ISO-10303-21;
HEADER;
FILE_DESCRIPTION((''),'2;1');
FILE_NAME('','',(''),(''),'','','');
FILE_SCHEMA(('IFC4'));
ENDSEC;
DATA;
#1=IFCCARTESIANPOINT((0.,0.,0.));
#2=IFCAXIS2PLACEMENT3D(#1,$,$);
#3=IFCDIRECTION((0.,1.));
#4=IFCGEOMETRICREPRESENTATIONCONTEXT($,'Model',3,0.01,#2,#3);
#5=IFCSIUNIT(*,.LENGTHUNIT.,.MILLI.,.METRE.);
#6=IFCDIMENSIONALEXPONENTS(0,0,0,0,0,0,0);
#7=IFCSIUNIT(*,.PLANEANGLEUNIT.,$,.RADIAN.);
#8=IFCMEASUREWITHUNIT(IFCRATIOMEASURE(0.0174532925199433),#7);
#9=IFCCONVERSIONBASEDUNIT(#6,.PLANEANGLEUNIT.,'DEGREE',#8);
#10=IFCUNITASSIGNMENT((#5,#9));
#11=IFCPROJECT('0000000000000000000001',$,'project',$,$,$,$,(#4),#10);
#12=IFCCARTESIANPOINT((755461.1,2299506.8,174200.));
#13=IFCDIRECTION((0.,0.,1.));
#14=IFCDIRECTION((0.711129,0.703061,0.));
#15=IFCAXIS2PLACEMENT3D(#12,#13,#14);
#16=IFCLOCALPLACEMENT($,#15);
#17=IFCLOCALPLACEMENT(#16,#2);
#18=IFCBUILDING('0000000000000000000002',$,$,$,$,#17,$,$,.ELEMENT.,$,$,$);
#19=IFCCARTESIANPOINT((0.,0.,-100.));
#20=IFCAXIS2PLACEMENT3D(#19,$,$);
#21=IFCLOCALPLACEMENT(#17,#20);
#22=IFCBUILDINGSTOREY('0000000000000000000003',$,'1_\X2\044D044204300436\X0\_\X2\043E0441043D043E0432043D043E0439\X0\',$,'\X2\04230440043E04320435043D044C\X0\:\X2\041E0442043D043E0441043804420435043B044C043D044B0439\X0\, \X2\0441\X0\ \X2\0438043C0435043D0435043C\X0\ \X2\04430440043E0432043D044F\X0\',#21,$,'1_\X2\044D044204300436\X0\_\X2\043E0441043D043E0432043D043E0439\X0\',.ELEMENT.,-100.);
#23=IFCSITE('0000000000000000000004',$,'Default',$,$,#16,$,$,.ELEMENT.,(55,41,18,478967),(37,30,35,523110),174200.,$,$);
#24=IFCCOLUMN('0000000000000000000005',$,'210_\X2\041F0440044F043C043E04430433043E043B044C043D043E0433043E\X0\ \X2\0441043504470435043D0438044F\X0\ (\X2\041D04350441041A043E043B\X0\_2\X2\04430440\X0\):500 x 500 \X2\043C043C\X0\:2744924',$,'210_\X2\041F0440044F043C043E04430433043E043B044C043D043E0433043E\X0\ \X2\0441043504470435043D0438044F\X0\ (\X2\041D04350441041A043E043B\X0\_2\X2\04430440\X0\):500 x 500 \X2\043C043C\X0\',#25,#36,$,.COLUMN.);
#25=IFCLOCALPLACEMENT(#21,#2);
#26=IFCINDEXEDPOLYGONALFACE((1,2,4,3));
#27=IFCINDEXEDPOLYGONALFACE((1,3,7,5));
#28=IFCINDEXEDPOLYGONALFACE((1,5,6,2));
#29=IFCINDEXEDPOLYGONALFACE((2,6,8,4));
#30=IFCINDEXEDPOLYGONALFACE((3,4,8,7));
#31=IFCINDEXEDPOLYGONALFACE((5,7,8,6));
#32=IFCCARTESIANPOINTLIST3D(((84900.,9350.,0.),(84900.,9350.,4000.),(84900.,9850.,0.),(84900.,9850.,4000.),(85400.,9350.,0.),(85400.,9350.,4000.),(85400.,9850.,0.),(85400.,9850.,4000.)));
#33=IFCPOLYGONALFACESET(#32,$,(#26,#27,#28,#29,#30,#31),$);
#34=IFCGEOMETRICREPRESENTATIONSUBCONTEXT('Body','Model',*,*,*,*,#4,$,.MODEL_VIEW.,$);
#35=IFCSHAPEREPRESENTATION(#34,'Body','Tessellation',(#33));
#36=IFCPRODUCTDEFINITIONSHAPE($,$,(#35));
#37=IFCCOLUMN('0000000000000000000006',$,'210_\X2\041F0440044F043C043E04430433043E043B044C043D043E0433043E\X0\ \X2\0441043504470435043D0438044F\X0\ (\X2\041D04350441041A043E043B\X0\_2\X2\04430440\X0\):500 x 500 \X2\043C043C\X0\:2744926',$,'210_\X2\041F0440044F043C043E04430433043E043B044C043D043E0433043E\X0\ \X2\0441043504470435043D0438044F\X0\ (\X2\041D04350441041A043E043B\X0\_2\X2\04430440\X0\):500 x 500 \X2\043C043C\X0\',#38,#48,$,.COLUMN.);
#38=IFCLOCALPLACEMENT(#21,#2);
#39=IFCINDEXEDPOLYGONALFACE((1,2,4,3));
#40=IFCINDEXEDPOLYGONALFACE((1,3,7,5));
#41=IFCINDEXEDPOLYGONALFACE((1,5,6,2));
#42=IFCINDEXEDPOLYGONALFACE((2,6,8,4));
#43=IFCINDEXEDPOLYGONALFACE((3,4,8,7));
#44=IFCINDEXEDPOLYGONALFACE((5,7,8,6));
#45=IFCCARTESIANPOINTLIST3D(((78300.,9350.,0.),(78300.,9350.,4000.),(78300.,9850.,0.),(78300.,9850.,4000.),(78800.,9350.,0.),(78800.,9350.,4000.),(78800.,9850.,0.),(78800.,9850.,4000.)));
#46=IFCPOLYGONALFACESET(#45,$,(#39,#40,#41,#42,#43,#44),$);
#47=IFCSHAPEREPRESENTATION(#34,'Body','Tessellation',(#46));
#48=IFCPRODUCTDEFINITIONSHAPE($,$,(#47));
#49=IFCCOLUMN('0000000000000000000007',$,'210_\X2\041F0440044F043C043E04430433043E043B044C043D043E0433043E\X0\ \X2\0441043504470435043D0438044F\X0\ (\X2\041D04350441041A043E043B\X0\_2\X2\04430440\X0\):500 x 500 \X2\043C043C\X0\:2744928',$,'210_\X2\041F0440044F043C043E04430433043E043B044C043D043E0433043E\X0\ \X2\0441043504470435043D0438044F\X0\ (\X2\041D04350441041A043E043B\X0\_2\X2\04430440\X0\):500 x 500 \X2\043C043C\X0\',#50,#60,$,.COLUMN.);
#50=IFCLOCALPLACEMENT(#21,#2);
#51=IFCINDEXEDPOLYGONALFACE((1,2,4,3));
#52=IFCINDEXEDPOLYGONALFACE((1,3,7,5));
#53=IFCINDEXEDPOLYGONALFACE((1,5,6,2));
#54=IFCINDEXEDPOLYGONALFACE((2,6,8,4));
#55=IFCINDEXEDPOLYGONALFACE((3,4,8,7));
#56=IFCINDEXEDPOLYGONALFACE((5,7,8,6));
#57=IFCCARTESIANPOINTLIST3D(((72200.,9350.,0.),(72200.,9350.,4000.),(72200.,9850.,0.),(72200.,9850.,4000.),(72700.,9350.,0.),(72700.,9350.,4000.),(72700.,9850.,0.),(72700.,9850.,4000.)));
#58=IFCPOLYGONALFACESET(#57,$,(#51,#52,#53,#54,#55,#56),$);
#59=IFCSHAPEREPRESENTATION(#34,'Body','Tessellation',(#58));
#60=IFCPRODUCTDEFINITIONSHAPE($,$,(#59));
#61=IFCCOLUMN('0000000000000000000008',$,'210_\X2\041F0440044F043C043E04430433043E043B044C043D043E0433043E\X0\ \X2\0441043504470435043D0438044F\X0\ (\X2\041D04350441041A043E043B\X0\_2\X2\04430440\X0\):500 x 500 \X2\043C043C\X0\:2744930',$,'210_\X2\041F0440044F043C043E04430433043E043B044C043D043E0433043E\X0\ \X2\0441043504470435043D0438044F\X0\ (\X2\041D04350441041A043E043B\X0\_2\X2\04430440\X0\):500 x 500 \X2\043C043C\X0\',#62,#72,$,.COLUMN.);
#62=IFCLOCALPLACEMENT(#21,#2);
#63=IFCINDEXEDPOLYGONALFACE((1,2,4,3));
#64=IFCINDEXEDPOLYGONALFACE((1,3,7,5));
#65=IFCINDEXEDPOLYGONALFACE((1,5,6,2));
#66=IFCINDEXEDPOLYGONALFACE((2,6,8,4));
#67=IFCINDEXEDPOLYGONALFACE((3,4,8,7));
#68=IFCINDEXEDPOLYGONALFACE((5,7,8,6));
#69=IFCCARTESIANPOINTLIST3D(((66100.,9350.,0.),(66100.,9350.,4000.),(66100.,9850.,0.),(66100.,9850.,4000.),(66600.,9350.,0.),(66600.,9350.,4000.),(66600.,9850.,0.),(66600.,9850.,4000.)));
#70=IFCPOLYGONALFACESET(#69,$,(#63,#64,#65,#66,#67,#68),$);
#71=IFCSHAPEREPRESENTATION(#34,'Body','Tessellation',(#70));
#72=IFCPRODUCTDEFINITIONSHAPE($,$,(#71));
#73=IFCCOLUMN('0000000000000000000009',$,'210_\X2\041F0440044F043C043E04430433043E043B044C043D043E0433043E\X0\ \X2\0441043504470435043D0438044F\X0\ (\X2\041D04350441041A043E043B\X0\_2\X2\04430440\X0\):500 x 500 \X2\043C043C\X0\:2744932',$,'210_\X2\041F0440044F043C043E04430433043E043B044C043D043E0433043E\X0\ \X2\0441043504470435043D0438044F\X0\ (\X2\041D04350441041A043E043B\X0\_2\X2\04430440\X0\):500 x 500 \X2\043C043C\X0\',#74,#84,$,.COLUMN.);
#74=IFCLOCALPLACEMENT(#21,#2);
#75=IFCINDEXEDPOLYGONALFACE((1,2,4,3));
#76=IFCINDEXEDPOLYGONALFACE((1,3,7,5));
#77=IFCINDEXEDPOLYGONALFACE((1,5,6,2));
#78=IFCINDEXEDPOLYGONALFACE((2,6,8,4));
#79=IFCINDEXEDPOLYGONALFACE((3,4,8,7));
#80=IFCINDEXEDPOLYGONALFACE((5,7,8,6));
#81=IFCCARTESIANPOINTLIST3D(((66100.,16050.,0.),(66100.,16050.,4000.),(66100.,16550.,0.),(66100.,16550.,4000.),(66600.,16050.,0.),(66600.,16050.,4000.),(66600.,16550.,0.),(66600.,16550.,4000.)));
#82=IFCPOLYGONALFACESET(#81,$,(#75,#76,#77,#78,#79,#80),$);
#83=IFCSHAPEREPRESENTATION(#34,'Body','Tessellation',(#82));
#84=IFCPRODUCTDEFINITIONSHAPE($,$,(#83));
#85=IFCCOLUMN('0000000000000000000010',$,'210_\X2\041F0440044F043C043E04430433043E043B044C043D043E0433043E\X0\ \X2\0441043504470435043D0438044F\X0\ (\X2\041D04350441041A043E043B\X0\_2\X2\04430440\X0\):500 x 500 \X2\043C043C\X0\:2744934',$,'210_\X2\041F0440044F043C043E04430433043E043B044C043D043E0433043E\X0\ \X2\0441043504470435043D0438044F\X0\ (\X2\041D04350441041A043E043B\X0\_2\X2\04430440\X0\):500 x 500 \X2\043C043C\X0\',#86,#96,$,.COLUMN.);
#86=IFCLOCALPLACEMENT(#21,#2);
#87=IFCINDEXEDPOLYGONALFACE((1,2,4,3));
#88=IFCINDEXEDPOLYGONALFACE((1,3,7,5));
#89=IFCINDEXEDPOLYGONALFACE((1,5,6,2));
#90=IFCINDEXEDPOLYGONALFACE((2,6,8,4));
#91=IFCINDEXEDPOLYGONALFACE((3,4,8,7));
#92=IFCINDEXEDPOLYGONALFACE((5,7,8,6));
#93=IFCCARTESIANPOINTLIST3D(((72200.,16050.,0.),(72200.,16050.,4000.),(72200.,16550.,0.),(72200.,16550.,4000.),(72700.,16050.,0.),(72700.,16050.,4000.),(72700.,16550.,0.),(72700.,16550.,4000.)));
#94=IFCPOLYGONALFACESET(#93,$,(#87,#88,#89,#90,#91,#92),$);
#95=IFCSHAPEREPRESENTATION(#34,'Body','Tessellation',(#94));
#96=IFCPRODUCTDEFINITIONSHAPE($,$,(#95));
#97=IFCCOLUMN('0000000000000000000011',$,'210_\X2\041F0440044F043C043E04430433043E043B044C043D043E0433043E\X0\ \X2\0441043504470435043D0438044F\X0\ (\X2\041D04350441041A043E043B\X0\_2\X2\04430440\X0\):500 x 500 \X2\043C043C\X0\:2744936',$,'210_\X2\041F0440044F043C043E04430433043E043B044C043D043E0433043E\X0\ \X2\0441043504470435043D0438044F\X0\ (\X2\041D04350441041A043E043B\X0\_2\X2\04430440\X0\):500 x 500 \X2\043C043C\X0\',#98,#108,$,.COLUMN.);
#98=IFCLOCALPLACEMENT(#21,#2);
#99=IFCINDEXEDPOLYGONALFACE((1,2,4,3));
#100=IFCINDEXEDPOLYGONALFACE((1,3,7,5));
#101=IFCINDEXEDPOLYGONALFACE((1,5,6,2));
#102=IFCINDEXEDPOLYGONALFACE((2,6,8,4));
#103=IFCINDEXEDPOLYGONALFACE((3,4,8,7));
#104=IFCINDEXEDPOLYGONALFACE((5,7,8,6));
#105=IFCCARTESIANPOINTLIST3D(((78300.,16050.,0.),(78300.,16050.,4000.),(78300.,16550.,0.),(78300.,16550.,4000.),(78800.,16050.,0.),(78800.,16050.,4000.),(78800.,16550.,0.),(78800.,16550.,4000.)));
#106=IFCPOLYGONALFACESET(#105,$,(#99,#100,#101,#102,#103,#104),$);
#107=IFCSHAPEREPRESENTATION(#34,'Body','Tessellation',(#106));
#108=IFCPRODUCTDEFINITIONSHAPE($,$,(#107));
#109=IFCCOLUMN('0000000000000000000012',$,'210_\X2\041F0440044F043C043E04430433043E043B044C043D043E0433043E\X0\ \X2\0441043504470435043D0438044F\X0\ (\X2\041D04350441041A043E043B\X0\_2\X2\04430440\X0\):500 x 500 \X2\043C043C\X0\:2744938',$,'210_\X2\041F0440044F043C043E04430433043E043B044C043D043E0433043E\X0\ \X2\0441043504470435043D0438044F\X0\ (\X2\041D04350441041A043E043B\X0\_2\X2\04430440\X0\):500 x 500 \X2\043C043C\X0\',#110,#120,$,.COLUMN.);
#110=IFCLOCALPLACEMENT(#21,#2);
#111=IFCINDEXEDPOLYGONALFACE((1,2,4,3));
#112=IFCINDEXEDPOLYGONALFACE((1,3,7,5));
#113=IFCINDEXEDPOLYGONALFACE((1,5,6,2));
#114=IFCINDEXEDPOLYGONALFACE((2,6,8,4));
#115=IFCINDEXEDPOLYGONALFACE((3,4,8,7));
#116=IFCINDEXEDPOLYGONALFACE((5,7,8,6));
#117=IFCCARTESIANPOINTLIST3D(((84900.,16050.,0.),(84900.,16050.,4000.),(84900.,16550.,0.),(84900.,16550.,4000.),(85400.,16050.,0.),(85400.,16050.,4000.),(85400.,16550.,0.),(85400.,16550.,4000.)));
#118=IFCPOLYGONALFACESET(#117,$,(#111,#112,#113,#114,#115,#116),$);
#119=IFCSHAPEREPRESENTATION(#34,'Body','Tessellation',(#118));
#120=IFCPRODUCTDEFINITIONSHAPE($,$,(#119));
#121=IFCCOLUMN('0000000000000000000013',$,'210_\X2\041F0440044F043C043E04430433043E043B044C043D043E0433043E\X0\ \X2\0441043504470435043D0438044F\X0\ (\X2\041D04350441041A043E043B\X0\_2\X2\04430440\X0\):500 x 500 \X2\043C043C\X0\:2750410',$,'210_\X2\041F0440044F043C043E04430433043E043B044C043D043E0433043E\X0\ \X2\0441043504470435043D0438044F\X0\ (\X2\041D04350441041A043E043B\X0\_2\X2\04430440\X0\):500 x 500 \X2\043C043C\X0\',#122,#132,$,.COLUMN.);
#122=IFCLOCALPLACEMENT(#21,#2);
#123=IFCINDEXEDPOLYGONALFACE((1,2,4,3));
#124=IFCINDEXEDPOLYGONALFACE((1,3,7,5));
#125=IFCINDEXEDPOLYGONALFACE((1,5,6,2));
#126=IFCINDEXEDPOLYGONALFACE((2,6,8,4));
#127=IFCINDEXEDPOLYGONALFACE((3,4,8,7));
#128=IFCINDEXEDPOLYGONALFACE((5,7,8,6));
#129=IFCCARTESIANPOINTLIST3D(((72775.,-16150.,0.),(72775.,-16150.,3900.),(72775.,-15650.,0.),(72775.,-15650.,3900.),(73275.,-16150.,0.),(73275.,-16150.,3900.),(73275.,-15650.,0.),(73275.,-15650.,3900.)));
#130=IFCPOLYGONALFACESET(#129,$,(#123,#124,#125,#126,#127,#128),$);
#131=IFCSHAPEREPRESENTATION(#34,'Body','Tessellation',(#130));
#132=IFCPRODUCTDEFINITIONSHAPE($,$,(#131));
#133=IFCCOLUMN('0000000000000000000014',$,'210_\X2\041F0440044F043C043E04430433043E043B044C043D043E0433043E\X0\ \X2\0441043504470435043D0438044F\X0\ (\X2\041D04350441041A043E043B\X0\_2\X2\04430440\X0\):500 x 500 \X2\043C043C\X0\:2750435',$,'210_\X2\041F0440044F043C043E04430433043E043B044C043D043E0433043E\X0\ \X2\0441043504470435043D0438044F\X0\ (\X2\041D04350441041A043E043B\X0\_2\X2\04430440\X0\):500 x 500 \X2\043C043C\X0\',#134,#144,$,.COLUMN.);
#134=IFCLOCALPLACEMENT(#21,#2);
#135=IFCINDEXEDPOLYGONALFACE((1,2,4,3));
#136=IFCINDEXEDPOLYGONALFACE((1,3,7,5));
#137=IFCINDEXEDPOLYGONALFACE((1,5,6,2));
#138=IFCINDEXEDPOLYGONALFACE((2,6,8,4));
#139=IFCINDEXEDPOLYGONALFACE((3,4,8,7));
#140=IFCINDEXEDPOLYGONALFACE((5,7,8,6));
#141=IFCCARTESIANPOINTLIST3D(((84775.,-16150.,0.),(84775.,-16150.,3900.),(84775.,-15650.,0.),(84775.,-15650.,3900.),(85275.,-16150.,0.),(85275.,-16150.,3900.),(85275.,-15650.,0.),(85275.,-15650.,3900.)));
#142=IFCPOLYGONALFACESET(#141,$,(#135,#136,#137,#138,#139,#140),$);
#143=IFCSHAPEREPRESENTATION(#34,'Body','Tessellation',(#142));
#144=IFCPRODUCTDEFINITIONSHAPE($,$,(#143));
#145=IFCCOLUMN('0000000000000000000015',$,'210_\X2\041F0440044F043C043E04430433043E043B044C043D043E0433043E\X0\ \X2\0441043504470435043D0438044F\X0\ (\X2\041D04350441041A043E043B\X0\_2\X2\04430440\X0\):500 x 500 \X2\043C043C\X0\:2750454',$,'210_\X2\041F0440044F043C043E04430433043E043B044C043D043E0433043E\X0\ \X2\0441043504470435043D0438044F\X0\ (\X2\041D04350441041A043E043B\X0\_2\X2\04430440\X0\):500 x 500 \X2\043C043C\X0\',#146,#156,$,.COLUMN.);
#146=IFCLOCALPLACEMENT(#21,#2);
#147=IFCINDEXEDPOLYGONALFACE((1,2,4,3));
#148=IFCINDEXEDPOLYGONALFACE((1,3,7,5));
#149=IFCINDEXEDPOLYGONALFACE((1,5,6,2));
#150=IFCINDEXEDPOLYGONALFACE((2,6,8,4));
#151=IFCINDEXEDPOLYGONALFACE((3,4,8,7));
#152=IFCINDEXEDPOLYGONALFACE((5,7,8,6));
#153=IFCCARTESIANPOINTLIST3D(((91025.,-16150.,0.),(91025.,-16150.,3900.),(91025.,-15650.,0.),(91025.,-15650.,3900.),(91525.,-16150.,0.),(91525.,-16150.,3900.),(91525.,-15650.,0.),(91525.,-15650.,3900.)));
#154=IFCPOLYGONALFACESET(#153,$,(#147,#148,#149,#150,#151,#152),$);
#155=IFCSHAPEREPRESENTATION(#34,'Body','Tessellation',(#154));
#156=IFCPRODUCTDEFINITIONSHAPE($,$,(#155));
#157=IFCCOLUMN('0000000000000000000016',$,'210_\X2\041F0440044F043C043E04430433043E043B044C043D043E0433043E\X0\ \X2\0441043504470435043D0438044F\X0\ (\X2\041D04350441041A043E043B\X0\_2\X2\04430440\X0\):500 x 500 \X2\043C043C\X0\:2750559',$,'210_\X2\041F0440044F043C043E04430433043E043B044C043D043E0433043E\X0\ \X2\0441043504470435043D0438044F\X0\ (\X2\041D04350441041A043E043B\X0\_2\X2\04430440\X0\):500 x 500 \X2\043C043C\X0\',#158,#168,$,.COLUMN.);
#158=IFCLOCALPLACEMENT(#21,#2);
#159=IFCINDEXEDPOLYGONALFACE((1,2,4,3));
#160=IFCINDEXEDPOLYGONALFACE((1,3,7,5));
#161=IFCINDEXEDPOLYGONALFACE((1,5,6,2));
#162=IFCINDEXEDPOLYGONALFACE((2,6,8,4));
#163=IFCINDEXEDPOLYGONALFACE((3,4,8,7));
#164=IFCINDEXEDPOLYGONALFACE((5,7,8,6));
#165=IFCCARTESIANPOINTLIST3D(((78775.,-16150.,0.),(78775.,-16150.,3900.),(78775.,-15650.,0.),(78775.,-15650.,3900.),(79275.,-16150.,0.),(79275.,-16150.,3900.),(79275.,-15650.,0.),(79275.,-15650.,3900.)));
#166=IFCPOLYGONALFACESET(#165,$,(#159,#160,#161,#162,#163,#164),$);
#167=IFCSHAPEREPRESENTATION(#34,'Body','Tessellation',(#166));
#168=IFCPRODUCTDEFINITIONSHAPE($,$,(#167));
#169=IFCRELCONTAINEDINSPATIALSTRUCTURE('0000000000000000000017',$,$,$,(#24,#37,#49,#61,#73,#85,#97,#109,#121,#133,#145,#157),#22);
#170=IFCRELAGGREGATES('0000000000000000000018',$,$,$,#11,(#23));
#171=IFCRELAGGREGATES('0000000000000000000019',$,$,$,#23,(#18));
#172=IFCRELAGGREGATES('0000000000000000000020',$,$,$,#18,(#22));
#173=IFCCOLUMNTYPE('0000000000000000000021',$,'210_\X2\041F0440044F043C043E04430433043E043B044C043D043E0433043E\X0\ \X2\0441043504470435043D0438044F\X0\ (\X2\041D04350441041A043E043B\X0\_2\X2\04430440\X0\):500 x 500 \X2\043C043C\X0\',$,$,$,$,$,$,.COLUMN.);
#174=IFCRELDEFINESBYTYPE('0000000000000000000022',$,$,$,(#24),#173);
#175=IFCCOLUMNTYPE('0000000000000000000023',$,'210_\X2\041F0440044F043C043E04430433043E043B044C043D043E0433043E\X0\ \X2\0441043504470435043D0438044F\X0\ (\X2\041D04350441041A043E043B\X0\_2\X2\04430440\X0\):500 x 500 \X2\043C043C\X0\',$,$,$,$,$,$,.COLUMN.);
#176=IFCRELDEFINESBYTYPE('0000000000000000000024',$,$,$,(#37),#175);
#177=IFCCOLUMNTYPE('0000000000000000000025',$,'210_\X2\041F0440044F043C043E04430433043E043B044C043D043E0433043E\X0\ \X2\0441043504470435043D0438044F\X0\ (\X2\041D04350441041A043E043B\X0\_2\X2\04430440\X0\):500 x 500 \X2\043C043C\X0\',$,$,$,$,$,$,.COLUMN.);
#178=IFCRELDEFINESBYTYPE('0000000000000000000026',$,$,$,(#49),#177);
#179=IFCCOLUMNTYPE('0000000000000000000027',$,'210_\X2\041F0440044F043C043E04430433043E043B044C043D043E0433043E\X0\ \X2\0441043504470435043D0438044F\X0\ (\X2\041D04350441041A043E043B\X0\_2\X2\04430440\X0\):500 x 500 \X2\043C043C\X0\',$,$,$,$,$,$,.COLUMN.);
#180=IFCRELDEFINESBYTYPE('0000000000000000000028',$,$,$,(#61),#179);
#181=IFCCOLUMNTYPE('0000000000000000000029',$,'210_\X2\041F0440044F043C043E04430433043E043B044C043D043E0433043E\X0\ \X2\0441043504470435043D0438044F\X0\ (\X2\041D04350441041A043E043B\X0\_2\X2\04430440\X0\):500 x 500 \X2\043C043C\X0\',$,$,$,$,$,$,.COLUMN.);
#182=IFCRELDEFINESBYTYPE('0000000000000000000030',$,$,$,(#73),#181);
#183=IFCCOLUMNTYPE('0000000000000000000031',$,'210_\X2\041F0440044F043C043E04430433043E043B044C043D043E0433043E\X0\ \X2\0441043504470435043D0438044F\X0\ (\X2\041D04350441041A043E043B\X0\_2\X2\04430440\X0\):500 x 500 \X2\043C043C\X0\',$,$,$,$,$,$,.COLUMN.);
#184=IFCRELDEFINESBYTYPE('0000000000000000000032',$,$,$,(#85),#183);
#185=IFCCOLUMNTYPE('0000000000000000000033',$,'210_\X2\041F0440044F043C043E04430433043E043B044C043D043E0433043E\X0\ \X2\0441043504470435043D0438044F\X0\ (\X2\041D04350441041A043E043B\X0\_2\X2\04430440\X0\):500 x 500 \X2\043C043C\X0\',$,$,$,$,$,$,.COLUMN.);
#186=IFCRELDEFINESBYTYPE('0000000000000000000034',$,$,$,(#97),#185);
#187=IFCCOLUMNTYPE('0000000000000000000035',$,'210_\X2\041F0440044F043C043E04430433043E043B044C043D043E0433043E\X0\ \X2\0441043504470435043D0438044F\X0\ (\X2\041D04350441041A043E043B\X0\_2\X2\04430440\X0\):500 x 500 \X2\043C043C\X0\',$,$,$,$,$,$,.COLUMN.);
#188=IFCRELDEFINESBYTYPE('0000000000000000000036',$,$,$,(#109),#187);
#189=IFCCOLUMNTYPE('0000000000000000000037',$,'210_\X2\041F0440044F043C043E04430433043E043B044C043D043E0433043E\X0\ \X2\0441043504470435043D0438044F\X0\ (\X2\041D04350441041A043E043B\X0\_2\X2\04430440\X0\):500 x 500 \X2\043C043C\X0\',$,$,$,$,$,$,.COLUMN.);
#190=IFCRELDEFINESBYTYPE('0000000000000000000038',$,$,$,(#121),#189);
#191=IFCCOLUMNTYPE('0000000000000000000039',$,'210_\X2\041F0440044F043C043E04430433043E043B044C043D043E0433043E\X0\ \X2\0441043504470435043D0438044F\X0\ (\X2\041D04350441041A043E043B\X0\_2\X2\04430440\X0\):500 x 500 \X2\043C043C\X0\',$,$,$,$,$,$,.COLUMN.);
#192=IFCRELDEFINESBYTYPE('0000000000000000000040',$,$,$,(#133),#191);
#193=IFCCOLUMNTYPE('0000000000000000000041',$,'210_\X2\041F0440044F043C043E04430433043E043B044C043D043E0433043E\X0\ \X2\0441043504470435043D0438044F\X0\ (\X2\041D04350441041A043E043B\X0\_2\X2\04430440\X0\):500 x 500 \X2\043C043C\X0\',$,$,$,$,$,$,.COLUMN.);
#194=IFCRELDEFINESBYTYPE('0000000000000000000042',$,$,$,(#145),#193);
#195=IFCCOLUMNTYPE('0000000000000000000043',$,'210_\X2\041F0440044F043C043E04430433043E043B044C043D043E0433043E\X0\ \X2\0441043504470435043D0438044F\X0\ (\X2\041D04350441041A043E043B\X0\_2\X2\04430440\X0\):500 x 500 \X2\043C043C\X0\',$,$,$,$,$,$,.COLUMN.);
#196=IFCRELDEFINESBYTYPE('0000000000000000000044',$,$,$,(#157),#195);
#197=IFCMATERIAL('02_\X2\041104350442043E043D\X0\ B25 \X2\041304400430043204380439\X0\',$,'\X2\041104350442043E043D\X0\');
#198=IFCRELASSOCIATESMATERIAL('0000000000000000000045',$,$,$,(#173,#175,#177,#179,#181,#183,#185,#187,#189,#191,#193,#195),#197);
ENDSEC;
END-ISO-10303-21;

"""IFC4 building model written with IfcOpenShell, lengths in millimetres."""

from ifc_helpers import new_model, entity, si_unit, converted_unit, direction, frame, origin, place, context, subcontext, project, spatial, indexed_curve, outline, extrude, source, transform, mapped, material, type_object, type_shapes, element, save


model = new_model("IFC4")

# Units and contexts
model_context = context("Model", 3, precision=0.01, world=origin(), true_north=direction((0.0, 1.0)))
body_context = subcontext(model_context, "Body", "Model", "MODEL_VIEW")
ifc_project = project(units=[si_unit("LENGTHUNIT", "METRE", prefix="MILLI"), converted_unit("PLANEANGLEUNIT", "DEGREE", entity("IfcRatioMeasure", 0.0174532925199433), si_unit("PLANEANGLEUNIT", "RADIAN"), dimensions=[0, 0, 0, 0, 0, 0, 0])], contexts=[model_context])

# Site, building, storey
site_placement = place(None, frame((755461.1, 2299506.8, 174200.0), z_axis=(0.0, 0.0, 1.0), x_axis=(0.711129, 0.703061, 0.0)))
site = spatial("IfcSite", under=ifc_project, at=site_placement, Name="Default", CompositionType="ELEMENT", RefLatitude=(55, 41, 18, 478967), RefLongitude=(37, 30, 35, 523110), RefElevation=174200.0)
building_placement = place(site_placement, origin())
building = spatial("IfcBuilding", under=site, at=building_placement, CompositionType="ELEMENT")
storey_placement = place(building_placement, frame((0.0, 0.0, -100.0)))
storey = spatial("IfcBuildingStorey", under=building, at=storey_placement, Name="1_этаж_основной", ObjectType="Уровень:Относительный, с именем уровня", LongName="1_этаж_основной", CompositionType="ELEMENT", Elevation=-100.0)

# Columns
ifc_material_1 = material(Name="02_Бетон B25 Гравий", Category="Бетон")
column_type_1 = type_object("IfcColumnType", Name="210_Прямоугольного сечения (НесКол_2ур):500 x 500 мм", PredefinedType="COLUMN", material=ifc_material_1)
shared_shape_1 = source(origin(), body_context, "Body", "SweptSolid", [
    extrude(outline(indexed_curve([(-250.0, -250.0), (250.0, -250.0), (250.0, 250.0), (-250.0, 250.0), (-250.0, -250.0)], self_intersect=False)), frame((85150.0, 9600.0, -100.0), z_axis=(0.0, 0.0, 1.0), x_axis=(0.0, -1.0, 0.0)), (0.0, 0.0, 1.0), 4000.0),
])
type_shapes(column_type_1, [shared_shape_1])
column_1_placement = place(storey_placement, frame((0.0, 0.0, 100.0)))
element("IfcColumn", 1, at=column_1_placement, inside=storey, type_object=column_type_1, Name="210_Прямоугольного сечения (НесКол_2ур):500 x 500 мм:2744924", ObjectType="210_Прямоугольного сечения (НесКол_2ур):500 x 500 мм", PredefinedType="COLUMN", context=body_context, shape_type="MappedRepresentation", body=[
    mapped(shared_shape_1, transform((0.0, 0.0, 0.0), scale=1.0)),
])
column_type_2 = type_object("IfcColumnType", Name="210_Прямоугольного сечения (НесКол_2ур):500 x 500 мм", PredefinedType="COLUMN", material=ifc_material_1)
shared_shape_2 = source(origin(), body_context, "Body", "SweptSolid", [
    extrude(outline(indexed_curve([(-250.0, -250.0), (250.0, -250.0), (250.0, 250.0), (-250.0, 250.0), (-250.0, -250.0)], self_intersect=False)), frame((78550.0, 9600.0, -100.0), z_axis=(0.0, 0.0, 1.0), x_axis=(0.0, -1.0, 0.0)), (0.0, 0.0, 1.0), 4000.0),
])
type_shapes(column_type_2, [shared_shape_2])
column_2_placement = place(storey_placement, frame((0.0, 0.0, 100.0)))
element("IfcColumn", 2, at=column_2_placement, inside=storey, type_object=column_type_2, Name="210_Прямоугольного сечения (НесКол_2ур):500 x 500 мм:2744926", ObjectType="210_Прямоугольного сечения (НесКол_2ур):500 x 500 мм", PredefinedType="COLUMN", context=body_context, shape_type="MappedRepresentation", body=[
    mapped(shared_shape_2, transform((0.0, 0.0, 0.0), scale=1.0)),
])
column_type_3 = type_object("IfcColumnType", Name="210_Прямоугольного сечения (НесКол_2ур):500 x 500 мм", PredefinedType="COLUMN", material=ifc_material_1)
shared_shape_3 = source(origin(), body_context, "Body", "SweptSolid", [
    extrude(outline(indexed_curve([(-250.0, -250.0), (250.0, -250.0), (250.0, 250.0), (-250.0, 250.0), (-250.0, -250.0)], self_intersect=False)), frame((72450.0, 9600.0, -100.0), z_axis=(0.0, 0.0, 1.0), x_axis=(0.0, -1.0, 0.0)), (0.0, 0.0, 1.0), 4000.0),
])
type_shapes(column_type_3, [shared_shape_3])
column_3_placement = place(storey_placement, frame((0.0, 0.0, 100.0)))
element("IfcColumn", 3, at=column_3_placement, inside=storey, type_object=column_type_3, Name="210_Прямоугольного сечения (НесКол_2ур):500 x 500 мм:2744928", ObjectType="210_Прямоугольного сечения (НесКол_2ур):500 x 500 мм", PredefinedType="COLUMN", context=body_context, shape_type="MappedRepresentation", body=[
    mapped(shared_shape_3, transform((0.0, 0.0, 0.0), scale=1.0)),
])
column_type_4 = type_object("IfcColumnType", Name="210_Прямоугольного сечения (НесКол_2ур):500 x 500 мм", PredefinedType="COLUMN", material=ifc_material_1)
shared_shape_4 = source(origin(), body_context, "Body", "SweptSolid", [
    extrude(outline(indexed_curve([(-250.0, -250.0), (250.0, -250.0), (250.0, 250.0), (-250.0, 250.0), (-250.0, -250.0)], self_intersect=False)), frame((66350.0, 9600.0, -100.0), z_axis=(0.0, 0.0, 1.0), x_axis=(0.0, -1.0, 0.0)), (0.0, 0.0, 1.0), 4000.0),
])
type_shapes(column_type_4, [shared_shape_4])
column_4_placement = place(storey_placement, frame((0.0, 0.0, 100.0)))
element("IfcColumn", 4, at=column_4_placement, inside=storey, type_object=column_type_4, Name="210_Прямоугольного сечения (НесКол_2ур):500 x 500 мм:2744930", ObjectType="210_Прямоугольного сечения (НесКол_2ур):500 x 500 мм", PredefinedType="COLUMN", context=body_context, shape_type="MappedRepresentation", body=[
    mapped(shared_shape_4, transform((0.0, 0.0, 0.0), scale=1.0)),
])
column_type_5 = type_object("IfcColumnType", Name="210_Прямоугольного сечения (НесКол_2ур):500 x 500 мм", PredefinedType="COLUMN", material=ifc_material_1)
shared_shape_5 = source(origin(), body_context, "Body", "SweptSolid", [
    extrude(outline(indexed_curve([(-250.0, -250.0), (250.0, -250.0), (250.0, 250.0), (-250.0, 250.0), (-250.0, -250.0)], self_intersect=False)), frame((66350.0, 16300.0, -100.0), z_axis=(0.0, 0.0, 1.0), x_axis=(0.0, -1.0, 0.0)), (0.0, 0.0, 1.0), 4000.0),
])
type_shapes(column_type_5, [shared_shape_5])
column_5_placement = place(storey_placement, frame((0.0, 0.0, 100.0)))
element("IfcColumn", 5, at=column_5_placement, inside=storey, type_object=column_type_5, Name="210_Прямоугольного сечения (НесКол_2ур):500 x 500 мм:2744932", ObjectType="210_Прямоугольного сечения (НесКол_2ур):500 x 500 мм", PredefinedType="COLUMN", context=body_context, shape_type="MappedRepresentation", body=[
    mapped(shared_shape_5, transform((0.0, 0.0, 0.0), scale=1.0)),
])
column_type_6 = type_object("IfcColumnType", Name="210_Прямоугольного сечения (НесКол_2ур):500 x 500 мм", PredefinedType="COLUMN", material=ifc_material_1)
shared_shape_6 = source(origin(), body_context, "Body", "SweptSolid", [
    extrude(outline(indexed_curve([(-250.0, -250.0), (250.0, -250.0), (250.0, 250.0), (-250.0, 250.0), (-250.0, -250.0)], self_intersect=False)), frame((72450.0, 16300.0, -100.0), z_axis=(0.0, 0.0, 1.0), x_axis=(0.0, -1.0, 0.0)), (0.0, 0.0, 1.0), 4000.0),
])
type_shapes(column_type_6, [shared_shape_6])
column_6_placement = place(storey_placement, frame((0.0, 0.0, 100.0)))
element("IfcColumn", 6, at=column_6_placement, inside=storey, type_object=column_type_6, Name="210_Прямоугольного сечения (НесКол_2ур):500 x 500 мм:2744934", ObjectType="210_Прямоугольного сечения (НесКол_2ур):500 x 500 мм", PredefinedType="COLUMN", context=body_context, shape_type="MappedRepresentation", body=[
    mapped(shared_shape_6, transform((0.0, 0.0, 0.0), scale=1.0)),
])
column_type_7 = type_object("IfcColumnType", Name="210_Прямоугольного сечения (НесКол_2ур):500 x 500 мм", PredefinedType="COLUMN", material=ifc_material_1)
shared_shape_7 = source(origin(), body_context, "Body", "SweptSolid", [
    extrude(outline(indexed_curve([(-250.0, -250.0), (250.0, -250.0), (250.0, 250.0), (-250.0, 250.0), (-250.0, -250.0)], self_intersect=False)), frame((78550.0, 16300.0, -100.0), z_axis=(0.0, 0.0, 1.0), x_axis=(0.0, -1.0, 0.0)), (0.0, 0.0, 1.0), 4000.0),
])
type_shapes(column_type_7, [shared_shape_7])
column_7_placement = place(storey_placement, frame((0.0, 0.0, 100.0)))
element("IfcColumn", 7, at=column_7_placement, inside=storey, type_object=column_type_7, Name="210_Прямоугольного сечения (НесКол_2ур):500 x 500 мм:2744936", ObjectType="210_Прямоугольного сечения (НесКол_2ур):500 x 500 мм", PredefinedType="COLUMN", context=body_context, shape_type="MappedRepresentation", body=[
    mapped(shared_shape_7, transform((0.0, 0.0, 0.0), scale=1.0)),
])
column_type_8 = type_object("IfcColumnType", Name="210_Прямоугольного сечения (НесКол_2ур):500 x 500 мм", PredefinedType="COLUMN", material=ifc_material_1)
shared_shape_8 = source(origin(), body_context, "Body", "SweptSolid", [
    extrude(outline(indexed_curve([(-250.0, -250.0), (250.0, -250.0), (250.0, 250.0), (-250.0, 250.0), (-250.0, -250.0)], self_intersect=False)), frame((85150.0, 16300.0, -100.0), z_axis=(0.0, 0.0, 1.0), x_axis=(0.0, -1.0, 0.0)), (0.0, 0.0, 1.0), 4000.0),
])
type_shapes(column_type_8, [shared_shape_8])
column_8_placement = place(storey_placement, frame((0.0, 0.0, 100.0)))
element("IfcColumn", 8, at=column_8_placement, inside=storey, type_object=column_type_8, Name="210_Прямоугольного сечения (НесКол_2ур):500 x 500 мм:2744938", ObjectType="210_Прямоугольного сечения (НесКол_2ур):500 x 500 мм", PredefinedType="COLUMN", context=body_context, shape_type="MappedRepresentation", body=[
    mapped(shared_shape_8, transform((0.0, 0.0, 0.0), scale=1.0)),
])
column_type_9 = type_object("IfcColumnType", Name="210_Прямоугольного сечения (НесКол_2ур):500 x 500 мм", PredefinedType="COLUMN", material=ifc_material_1)
shared_shape_9 = source(origin(), body_context, "Body", "SweptSolid", [
    extrude(outline(indexed_curve([(-250.0, -250.0), (250.0, -250.0), (250.0, 250.0), (-250.0, 250.0), (-250.0, -250.0)], self_intersect=False)), frame((73025.0, -15900.0, -100.0), z_axis=(0.0, 0.0, 1.0), x_axis=(0.0, -1.0, 0.0)), (0.0, 0.0, 1.0), 3900.0),
])
type_shapes(column_type_9, [shared_shape_9])
column_9_placement = place(storey_placement, frame((0.0, 0.0, 100.0)))
element("IfcColumn", 9, at=column_9_placement, inside=storey, type_object=column_type_9, Name="210_Прямоугольного сечения (НесКол_2ур):500 x 500 мм:2750410", ObjectType="210_Прямоугольного сечения (НесКол_2ур):500 x 500 мм", PredefinedType="COLUMN", context=body_context, shape_type="MappedRepresentation", body=[
    mapped(shared_shape_9, transform((0.0, 0.0, 0.0), scale=1.0)),
])
column_type_10 = type_object("IfcColumnType", Name="210_Прямоугольного сечения (НесКол_2ур):500 x 500 мм", PredefinedType="COLUMN", material=ifc_material_1)
shared_shape_10 = source(origin(), body_context, "Body", "SweptSolid", [
    extrude(outline(indexed_curve([(-250.0, -250.0), (250.0, -250.0), (250.0, 250.0), (-250.0, 250.0), (-250.0, -250.0)], self_intersect=False)), frame((85025.0, -15900.0, -100.0), z_axis=(0.0, 0.0, 1.0), x_axis=(0.0, -1.0, 0.0)), (0.0, 0.0, 1.0), 3900.0),
])
type_shapes(column_type_10, [shared_shape_10])
column_10_placement = place(storey_placement, frame((0.0, 0.0, 100.0)))
element("IfcColumn", 10, at=column_10_placement, inside=storey, type_object=column_type_10, Name="210_Прямоугольного сечения (НесКол_2ур):500 x 500 мм:2750435", ObjectType="210_Прямоугольного сечения (НесКол_2ур):500 x 500 мм", PredefinedType="COLUMN", context=body_context, shape_type="MappedRepresentation", body=[
    mapped(shared_shape_10, transform((0.0, 0.0, 0.0), scale=1.0)),
])
column_type_11 = type_object("IfcColumnType", Name="210_Прямоугольного сечения (НесКол_2ур):500 x 500 мм", PredefinedType="COLUMN", material=ifc_material_1)
shared_shape_11 = source(origin(), body_context, "Body", "SweptSolid", [
    extrude(outline(indexed_curve([(-250.0, -250.0), (250.0, -250.0), (250.0, 250.0), (-250.0, 250.0), (-250.0, -250.0)], self_intersect=False)), frame((91275.0, -15900.0, -100.0), z_axis=(0.0, 0.0, 1.0), x_axis=(0.0, -1.0, 0.0)), (0.0, 0.0, 1.0), 3900.0),
])
type_shapes(column_type_11, [shared_shape_11])
column_11_placement = place(storey_placement, frame((0.0, 0.0, 100.0)))
element("IfcColumn", 11, at=column_11_placement, inside=storey, type_object=column_type_11, Name="210_Прямоугольного сечения (НесКол_2ур):500 x 500 мм:2750454", ObjectType="210_Прямоугольного сечения (НесКол_2ур):500 x 500 мм", PredefinedType="COLUMN", context=body_context, shape_type="MappedRepresentation", body=[
    mapped(shared_shape_11, transform((0.0, 0.0, 0.0), scale=1.0)),
])
column_type_12 = type_object("IfcColumnType", Name="210_Прямоугольного сечения (НесКол_2ур):500 x 500 мм", PredefinedType="COLUMN", material=ifc_material_1)
shared_shape_12 = source(origin(), body_context, "Body", "SweptSolid", [
    extrude(outline(indexed_curve([(-250.0, -250.0), (250.0, -250.0), (250.0, 250.0), (-250.0, 250.0), (-250.0, -250.0)], self_intersect=False)), frame((79025.0, -15900.0, -100.0), z_axis=(0.0, 0.0, 1.0), x_axis=(0.0, -1.0, 0.0)), (0.0, 0.0, 1.0), 3900.0),
])
type_shapes(column_type_12, [shared_shape_12])
column_12_placement = place(storey_placement, frame((0.0, 0.0, 100.0)))
element("IfcColumn", 12, at=column_12_placement, inside=storey, type_object=column_type_12, Name="210_Прямоугольного сечения (НесКол_2ур):500 x 500 мм:2750559", ObjectType="210_Прямоугольного сечения (НесКол_2ур):500 x 500 мм", PredefinedType="COLUMN", context=body_context, shape_type="MappedRepresentation", body=[
    mapped(shared_shape_12, transform((0.0, 0.0, 0.0), scale=1.0)),
])

save(model, "model.ifc")
